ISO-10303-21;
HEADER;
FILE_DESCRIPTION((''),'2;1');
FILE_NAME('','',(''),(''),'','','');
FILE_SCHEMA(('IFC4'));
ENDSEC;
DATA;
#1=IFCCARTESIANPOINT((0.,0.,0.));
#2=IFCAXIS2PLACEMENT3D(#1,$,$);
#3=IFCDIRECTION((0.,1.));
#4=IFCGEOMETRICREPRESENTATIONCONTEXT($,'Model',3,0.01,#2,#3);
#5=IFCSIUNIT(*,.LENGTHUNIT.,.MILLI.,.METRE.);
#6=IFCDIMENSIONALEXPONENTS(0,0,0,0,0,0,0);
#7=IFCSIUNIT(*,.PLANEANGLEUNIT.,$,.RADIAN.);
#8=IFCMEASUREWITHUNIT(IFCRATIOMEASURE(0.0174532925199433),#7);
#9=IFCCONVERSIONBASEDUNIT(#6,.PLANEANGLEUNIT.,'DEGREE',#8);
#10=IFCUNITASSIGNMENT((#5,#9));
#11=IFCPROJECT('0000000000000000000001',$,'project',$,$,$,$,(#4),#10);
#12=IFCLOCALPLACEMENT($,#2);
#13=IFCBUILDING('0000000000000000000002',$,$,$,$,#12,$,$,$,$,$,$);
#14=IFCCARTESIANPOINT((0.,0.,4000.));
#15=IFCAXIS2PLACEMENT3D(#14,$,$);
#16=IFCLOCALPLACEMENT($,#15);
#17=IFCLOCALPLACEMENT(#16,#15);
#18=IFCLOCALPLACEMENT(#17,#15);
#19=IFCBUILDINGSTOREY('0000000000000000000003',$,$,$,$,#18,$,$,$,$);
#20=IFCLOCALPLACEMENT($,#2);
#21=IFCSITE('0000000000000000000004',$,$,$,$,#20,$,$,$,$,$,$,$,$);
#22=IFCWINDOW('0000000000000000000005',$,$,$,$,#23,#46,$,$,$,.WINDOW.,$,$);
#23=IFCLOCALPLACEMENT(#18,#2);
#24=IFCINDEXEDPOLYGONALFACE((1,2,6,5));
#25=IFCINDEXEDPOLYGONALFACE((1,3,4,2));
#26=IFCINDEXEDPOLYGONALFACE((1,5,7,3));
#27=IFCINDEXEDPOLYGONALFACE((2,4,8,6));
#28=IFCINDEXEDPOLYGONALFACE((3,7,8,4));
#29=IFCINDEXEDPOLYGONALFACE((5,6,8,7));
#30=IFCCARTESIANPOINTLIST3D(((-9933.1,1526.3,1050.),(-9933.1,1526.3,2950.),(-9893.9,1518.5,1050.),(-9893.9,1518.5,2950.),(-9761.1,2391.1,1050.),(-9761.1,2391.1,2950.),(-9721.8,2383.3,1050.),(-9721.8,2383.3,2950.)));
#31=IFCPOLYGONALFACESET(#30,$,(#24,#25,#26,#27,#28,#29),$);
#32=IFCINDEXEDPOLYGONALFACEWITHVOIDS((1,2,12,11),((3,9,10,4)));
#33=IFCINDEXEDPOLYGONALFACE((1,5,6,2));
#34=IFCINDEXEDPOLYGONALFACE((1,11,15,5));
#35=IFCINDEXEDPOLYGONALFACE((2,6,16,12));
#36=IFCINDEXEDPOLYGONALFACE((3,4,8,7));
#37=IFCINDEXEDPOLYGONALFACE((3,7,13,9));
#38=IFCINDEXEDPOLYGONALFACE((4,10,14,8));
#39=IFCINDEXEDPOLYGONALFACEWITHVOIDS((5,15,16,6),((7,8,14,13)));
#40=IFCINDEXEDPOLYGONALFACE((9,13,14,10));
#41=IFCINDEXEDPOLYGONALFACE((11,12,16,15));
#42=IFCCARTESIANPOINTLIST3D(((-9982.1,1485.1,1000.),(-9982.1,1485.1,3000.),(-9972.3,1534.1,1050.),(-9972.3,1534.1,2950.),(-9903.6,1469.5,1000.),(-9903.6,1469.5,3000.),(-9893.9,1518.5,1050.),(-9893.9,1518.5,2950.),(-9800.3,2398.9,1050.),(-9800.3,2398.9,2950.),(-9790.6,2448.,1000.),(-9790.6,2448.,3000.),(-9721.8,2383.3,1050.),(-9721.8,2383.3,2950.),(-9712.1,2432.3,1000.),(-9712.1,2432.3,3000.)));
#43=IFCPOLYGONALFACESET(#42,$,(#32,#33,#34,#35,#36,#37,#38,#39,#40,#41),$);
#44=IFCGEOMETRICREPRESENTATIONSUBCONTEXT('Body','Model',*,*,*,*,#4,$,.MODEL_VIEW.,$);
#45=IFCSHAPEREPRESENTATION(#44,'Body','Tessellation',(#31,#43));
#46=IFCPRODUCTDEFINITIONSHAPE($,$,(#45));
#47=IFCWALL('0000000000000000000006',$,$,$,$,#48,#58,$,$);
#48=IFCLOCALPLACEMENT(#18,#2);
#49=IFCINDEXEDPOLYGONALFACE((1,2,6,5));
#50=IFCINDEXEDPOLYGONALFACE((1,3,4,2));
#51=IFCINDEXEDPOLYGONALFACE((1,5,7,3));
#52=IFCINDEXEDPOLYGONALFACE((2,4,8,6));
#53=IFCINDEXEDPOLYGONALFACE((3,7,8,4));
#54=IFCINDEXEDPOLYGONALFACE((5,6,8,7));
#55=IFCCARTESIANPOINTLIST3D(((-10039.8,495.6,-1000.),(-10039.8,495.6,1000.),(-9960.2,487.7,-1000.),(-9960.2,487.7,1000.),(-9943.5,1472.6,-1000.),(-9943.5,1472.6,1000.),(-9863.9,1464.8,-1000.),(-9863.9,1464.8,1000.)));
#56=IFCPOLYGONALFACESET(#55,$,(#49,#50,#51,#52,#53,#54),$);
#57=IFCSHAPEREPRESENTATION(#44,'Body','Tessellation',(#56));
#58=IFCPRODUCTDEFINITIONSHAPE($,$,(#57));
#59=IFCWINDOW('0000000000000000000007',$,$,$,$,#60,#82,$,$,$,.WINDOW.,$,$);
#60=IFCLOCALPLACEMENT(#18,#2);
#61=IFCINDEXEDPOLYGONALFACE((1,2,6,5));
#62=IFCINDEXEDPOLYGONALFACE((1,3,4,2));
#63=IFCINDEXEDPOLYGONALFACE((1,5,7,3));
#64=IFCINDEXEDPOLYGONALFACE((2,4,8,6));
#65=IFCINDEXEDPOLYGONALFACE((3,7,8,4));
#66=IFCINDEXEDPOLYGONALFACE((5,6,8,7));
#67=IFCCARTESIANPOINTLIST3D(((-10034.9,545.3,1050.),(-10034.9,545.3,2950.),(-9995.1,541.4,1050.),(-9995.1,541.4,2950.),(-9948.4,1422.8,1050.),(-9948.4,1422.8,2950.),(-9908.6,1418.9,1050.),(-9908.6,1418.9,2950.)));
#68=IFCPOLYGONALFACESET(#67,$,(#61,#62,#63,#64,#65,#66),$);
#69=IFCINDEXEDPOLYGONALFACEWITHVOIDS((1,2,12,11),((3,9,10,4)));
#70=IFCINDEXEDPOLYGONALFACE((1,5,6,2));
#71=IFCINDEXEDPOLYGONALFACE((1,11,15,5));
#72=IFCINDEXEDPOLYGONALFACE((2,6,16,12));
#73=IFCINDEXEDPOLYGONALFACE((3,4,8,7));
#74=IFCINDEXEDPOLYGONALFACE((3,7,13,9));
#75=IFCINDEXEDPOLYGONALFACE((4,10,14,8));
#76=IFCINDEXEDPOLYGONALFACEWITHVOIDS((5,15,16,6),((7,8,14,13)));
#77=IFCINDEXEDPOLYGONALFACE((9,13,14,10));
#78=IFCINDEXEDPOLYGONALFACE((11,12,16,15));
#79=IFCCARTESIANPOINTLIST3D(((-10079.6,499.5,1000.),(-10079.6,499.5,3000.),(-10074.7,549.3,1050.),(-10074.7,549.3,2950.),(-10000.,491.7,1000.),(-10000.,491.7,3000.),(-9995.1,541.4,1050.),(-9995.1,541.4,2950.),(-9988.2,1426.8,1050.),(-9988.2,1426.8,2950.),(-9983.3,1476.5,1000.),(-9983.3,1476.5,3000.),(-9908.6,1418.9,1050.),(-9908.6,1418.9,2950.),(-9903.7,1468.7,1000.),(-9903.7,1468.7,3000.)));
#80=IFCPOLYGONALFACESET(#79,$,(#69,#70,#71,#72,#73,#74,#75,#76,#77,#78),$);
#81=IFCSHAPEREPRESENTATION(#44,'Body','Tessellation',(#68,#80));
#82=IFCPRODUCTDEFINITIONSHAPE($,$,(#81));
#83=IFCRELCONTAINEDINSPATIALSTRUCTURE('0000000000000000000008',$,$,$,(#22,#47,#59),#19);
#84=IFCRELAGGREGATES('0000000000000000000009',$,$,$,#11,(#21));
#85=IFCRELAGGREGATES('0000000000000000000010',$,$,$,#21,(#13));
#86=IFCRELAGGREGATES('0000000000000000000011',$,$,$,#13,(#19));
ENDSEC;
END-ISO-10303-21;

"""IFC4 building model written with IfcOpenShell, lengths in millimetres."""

from ifc_helpers import new_model, entity, si_unit, converted_unit, direction, frame, origin, origin_2d, place, context, subcontext, project, spatial, rectangle, extrude, element, save


model = new_model("IFC4")

# Units and contexts
model_context = context("Model", 3, precision=0.01, world=origin(), true_north=direction((0.0, 1.0)))
body_context = subcontext(model_context, "Body", "Model", "MODEL_VIEW")
ifc_project = project(units=[si_unit("LENGTHUNIT", "METRE", prefix="MILLI"), converted_unit("PLANEANGLEUNIT", "DEGREE", entity("IfcRatioMeasure", 0.0174532925199433), si_unit("PLANEANGLEUNIT", "RADIAN"), dimensions=[0, 0, 0, 0, 0, 0, 0])], contexts=[model_context])

# Site, building, storey
site_placement = place(None, origin())
site = spatial("IfcSite", under=ifc_project, at=site_placement)
building_placement = place(None, origin())
building = spatial("IfcBuilding", under=site, at=building_placement)
placement_1 = place(None, frame((0.0, 0.0, 4000.0)))
placement_2 = place(placement_1, frame((0.0, 0.0, 4000.0)))
storey_placement = place(placement_2, frame((0.0, 0.0, 4000.0)))
storey = spatial("IfcBuildingStorey", under=building, at=storey_placement)

# Shared definitions
cartesian_point_1 = entity("IfcCartesianPoint", [-440.9, -950.0])
shared_polyline = entity("IfcPolyline", [cartesian_point_1, entity("IfcCartesianPoint", [-440.9, 950.0]), entity("IfcCartesianPoint", [-440.9, 950.0]), entity("IfcCartesianPoint", [440.9, 950.0]), entity("IfcCartesianPoint", [440.9, 950.0]), entity("IfcCartesianPoint", [440.9, -950.0]), entity("IfcCartesianPoint", [440.9, -950.0]), entity("IfcCartesianPoint", [-440.9, -950.0]), cartesian_point_1])

# Window
window_1_placement = place(storey_placement, frame((-9807.9, 1950.9, 2000.0), z_axis=(0.0, 0.0, 1.0), x_axis=(-1950.903147, -9807.852819, 0.0)))
cartesian_point_2 = entity("IfcCartesianPoint", [-490.9, -1000.0])
element("IfcWindow", 1, at=window_1_placement, inside=storey, PredefinedType="WINDOW", context=body_context, shape_type="SweptSolid", body=[
    entity("IfcExtrudedAreaSolid", entity("IfcArbitraryClosedProfileDef", "AREA", None, shared_polyline), entity("IfcAxis2Placement3D", entity("IfcCartesianPoint", [0.0, 0.0, 0.0]), entity("IfcDirection", [0.0, -1.0, 0.0]), entity("IfcDirection", [1.0, 0.0, 0.0])), entity("IfcDirection", [0.0, 0.0, 1.0]), 40.0),
    entity("IfcExtrudedAreaSolid", entity("IfcArbitraryProfileDefWithVoids", "AREA", None, entity("IfcPolyline", [cartesian_point_2, entity("IfcCartesianPoint", [-490.9, 1000.0]), entity("IfcCartesianPoint", [-490.9, 1000.0]), entity("IfcCartesianPoint", [490.9, 1000.0]), entity("IfcCartesianPoint", [490.9, 1000.0]), entity("IfcCartesianPoint", [490.9, -1000.0]), entity("IfcCartesianPoint", [490.9, -1000.0]), entity("IfcCartesianPoint", [-490.9, -1000.0]), cartesian_point_2]), [shared_polyline]), entity("IfcAxis2Placement3D", entity("IfcCartesianPoint", [0.0, 0.0, 0.0]), entity("IfcDirection", [0.0, -1.0, 0.0]), entity("IfcDirection", [1.0, 0.0, 0.0])), entity("IfcDirection", [0.0, 0.0, 1.0]), 80.0),
])

# Wall
wall_1_placement = place(storey_placement, frame((-9951.8, 980.2, -1000.0), z_axis=(0.0, 0.0, 1.0), x_axis=(-980.170931, -9951.847313, 0.0)))
element("IfcWall", 2, at=wall_1_placement, inside=storey, context=body_context, shape_type="SweptSolid", body=[
    extrude(rectangle(XDim=981.7, YDim=80.0, at=origin_2d()), origin(), (0.0, 0.0, 1.0), 2000.0),
])

# Window
window_2_placement = place(storey_placement, frame((-9951.8, 980.2, 2000.0), z_axis=(0.0, 0.0, 1.0), x_axis=(-980.170931, -9951.847313, 0.0)))
cartesian_point_3 = entity("IfcCartesianPoint", [-490.9, -1000.0])
element("IfcWindow", 3, at=window_2_placement, inside=storey, PredefinedType="WINDOW", context=body_context, shape_type="SweptSolid", body=[
    entity("IfcExtrudedAreaSolid", entity("IfcArbitraryClosedProfileDef", "AREA", None, shared_polyline), entity("IfcAxis2Placement3D", entity("IfcCartesianPoint", [0.0, 0.0, 0.0]), entity("IfcDirection", [0.0, -1.0, 0.0]), entity("IfcDirection", [1.0, 0.0, 0.0])), entity("IfcDirection", [0.0, 0.0, 1.0]), 40.0),
    entity("IfcExtrudedAreaSolid", entity("IfcArbitraryProfileDefWithVoids", "AREA", None, entity("IfcPolyline", [cartesian_point_3, entity("IfcCartesianPoint", [-490.9, 1000.0]), entity("IfcCartesianPoint", [-490.9, 1000.0]), entity("IfcCartesianPoint", [490.9, 1000.0]), entity("IfcCartesianPoint", [490.9, 1000.0]), entity("IfcCartesianPoint", [490.9, -1000.0]), entity("IfcCartesianPoint", [490.9, -1000.0]), entity("IfcCartesianPoint", [-490.9, -1000.0]), cartesian_point_3]), [shared_polyline]), entity("IfcAxis2Placement3D", entity("IfcCartesianPoint", [0.0, 0.0, 0.0]), entity("IfcDirection", [0.0, -1.0, 0.0]), entity("IfcDirection", [1.0, 0.0, 0.0])), entity("IfcDirection", [0.0, 0.0, 1.0]), 80.0),
])

save(model, "model.ifc")
